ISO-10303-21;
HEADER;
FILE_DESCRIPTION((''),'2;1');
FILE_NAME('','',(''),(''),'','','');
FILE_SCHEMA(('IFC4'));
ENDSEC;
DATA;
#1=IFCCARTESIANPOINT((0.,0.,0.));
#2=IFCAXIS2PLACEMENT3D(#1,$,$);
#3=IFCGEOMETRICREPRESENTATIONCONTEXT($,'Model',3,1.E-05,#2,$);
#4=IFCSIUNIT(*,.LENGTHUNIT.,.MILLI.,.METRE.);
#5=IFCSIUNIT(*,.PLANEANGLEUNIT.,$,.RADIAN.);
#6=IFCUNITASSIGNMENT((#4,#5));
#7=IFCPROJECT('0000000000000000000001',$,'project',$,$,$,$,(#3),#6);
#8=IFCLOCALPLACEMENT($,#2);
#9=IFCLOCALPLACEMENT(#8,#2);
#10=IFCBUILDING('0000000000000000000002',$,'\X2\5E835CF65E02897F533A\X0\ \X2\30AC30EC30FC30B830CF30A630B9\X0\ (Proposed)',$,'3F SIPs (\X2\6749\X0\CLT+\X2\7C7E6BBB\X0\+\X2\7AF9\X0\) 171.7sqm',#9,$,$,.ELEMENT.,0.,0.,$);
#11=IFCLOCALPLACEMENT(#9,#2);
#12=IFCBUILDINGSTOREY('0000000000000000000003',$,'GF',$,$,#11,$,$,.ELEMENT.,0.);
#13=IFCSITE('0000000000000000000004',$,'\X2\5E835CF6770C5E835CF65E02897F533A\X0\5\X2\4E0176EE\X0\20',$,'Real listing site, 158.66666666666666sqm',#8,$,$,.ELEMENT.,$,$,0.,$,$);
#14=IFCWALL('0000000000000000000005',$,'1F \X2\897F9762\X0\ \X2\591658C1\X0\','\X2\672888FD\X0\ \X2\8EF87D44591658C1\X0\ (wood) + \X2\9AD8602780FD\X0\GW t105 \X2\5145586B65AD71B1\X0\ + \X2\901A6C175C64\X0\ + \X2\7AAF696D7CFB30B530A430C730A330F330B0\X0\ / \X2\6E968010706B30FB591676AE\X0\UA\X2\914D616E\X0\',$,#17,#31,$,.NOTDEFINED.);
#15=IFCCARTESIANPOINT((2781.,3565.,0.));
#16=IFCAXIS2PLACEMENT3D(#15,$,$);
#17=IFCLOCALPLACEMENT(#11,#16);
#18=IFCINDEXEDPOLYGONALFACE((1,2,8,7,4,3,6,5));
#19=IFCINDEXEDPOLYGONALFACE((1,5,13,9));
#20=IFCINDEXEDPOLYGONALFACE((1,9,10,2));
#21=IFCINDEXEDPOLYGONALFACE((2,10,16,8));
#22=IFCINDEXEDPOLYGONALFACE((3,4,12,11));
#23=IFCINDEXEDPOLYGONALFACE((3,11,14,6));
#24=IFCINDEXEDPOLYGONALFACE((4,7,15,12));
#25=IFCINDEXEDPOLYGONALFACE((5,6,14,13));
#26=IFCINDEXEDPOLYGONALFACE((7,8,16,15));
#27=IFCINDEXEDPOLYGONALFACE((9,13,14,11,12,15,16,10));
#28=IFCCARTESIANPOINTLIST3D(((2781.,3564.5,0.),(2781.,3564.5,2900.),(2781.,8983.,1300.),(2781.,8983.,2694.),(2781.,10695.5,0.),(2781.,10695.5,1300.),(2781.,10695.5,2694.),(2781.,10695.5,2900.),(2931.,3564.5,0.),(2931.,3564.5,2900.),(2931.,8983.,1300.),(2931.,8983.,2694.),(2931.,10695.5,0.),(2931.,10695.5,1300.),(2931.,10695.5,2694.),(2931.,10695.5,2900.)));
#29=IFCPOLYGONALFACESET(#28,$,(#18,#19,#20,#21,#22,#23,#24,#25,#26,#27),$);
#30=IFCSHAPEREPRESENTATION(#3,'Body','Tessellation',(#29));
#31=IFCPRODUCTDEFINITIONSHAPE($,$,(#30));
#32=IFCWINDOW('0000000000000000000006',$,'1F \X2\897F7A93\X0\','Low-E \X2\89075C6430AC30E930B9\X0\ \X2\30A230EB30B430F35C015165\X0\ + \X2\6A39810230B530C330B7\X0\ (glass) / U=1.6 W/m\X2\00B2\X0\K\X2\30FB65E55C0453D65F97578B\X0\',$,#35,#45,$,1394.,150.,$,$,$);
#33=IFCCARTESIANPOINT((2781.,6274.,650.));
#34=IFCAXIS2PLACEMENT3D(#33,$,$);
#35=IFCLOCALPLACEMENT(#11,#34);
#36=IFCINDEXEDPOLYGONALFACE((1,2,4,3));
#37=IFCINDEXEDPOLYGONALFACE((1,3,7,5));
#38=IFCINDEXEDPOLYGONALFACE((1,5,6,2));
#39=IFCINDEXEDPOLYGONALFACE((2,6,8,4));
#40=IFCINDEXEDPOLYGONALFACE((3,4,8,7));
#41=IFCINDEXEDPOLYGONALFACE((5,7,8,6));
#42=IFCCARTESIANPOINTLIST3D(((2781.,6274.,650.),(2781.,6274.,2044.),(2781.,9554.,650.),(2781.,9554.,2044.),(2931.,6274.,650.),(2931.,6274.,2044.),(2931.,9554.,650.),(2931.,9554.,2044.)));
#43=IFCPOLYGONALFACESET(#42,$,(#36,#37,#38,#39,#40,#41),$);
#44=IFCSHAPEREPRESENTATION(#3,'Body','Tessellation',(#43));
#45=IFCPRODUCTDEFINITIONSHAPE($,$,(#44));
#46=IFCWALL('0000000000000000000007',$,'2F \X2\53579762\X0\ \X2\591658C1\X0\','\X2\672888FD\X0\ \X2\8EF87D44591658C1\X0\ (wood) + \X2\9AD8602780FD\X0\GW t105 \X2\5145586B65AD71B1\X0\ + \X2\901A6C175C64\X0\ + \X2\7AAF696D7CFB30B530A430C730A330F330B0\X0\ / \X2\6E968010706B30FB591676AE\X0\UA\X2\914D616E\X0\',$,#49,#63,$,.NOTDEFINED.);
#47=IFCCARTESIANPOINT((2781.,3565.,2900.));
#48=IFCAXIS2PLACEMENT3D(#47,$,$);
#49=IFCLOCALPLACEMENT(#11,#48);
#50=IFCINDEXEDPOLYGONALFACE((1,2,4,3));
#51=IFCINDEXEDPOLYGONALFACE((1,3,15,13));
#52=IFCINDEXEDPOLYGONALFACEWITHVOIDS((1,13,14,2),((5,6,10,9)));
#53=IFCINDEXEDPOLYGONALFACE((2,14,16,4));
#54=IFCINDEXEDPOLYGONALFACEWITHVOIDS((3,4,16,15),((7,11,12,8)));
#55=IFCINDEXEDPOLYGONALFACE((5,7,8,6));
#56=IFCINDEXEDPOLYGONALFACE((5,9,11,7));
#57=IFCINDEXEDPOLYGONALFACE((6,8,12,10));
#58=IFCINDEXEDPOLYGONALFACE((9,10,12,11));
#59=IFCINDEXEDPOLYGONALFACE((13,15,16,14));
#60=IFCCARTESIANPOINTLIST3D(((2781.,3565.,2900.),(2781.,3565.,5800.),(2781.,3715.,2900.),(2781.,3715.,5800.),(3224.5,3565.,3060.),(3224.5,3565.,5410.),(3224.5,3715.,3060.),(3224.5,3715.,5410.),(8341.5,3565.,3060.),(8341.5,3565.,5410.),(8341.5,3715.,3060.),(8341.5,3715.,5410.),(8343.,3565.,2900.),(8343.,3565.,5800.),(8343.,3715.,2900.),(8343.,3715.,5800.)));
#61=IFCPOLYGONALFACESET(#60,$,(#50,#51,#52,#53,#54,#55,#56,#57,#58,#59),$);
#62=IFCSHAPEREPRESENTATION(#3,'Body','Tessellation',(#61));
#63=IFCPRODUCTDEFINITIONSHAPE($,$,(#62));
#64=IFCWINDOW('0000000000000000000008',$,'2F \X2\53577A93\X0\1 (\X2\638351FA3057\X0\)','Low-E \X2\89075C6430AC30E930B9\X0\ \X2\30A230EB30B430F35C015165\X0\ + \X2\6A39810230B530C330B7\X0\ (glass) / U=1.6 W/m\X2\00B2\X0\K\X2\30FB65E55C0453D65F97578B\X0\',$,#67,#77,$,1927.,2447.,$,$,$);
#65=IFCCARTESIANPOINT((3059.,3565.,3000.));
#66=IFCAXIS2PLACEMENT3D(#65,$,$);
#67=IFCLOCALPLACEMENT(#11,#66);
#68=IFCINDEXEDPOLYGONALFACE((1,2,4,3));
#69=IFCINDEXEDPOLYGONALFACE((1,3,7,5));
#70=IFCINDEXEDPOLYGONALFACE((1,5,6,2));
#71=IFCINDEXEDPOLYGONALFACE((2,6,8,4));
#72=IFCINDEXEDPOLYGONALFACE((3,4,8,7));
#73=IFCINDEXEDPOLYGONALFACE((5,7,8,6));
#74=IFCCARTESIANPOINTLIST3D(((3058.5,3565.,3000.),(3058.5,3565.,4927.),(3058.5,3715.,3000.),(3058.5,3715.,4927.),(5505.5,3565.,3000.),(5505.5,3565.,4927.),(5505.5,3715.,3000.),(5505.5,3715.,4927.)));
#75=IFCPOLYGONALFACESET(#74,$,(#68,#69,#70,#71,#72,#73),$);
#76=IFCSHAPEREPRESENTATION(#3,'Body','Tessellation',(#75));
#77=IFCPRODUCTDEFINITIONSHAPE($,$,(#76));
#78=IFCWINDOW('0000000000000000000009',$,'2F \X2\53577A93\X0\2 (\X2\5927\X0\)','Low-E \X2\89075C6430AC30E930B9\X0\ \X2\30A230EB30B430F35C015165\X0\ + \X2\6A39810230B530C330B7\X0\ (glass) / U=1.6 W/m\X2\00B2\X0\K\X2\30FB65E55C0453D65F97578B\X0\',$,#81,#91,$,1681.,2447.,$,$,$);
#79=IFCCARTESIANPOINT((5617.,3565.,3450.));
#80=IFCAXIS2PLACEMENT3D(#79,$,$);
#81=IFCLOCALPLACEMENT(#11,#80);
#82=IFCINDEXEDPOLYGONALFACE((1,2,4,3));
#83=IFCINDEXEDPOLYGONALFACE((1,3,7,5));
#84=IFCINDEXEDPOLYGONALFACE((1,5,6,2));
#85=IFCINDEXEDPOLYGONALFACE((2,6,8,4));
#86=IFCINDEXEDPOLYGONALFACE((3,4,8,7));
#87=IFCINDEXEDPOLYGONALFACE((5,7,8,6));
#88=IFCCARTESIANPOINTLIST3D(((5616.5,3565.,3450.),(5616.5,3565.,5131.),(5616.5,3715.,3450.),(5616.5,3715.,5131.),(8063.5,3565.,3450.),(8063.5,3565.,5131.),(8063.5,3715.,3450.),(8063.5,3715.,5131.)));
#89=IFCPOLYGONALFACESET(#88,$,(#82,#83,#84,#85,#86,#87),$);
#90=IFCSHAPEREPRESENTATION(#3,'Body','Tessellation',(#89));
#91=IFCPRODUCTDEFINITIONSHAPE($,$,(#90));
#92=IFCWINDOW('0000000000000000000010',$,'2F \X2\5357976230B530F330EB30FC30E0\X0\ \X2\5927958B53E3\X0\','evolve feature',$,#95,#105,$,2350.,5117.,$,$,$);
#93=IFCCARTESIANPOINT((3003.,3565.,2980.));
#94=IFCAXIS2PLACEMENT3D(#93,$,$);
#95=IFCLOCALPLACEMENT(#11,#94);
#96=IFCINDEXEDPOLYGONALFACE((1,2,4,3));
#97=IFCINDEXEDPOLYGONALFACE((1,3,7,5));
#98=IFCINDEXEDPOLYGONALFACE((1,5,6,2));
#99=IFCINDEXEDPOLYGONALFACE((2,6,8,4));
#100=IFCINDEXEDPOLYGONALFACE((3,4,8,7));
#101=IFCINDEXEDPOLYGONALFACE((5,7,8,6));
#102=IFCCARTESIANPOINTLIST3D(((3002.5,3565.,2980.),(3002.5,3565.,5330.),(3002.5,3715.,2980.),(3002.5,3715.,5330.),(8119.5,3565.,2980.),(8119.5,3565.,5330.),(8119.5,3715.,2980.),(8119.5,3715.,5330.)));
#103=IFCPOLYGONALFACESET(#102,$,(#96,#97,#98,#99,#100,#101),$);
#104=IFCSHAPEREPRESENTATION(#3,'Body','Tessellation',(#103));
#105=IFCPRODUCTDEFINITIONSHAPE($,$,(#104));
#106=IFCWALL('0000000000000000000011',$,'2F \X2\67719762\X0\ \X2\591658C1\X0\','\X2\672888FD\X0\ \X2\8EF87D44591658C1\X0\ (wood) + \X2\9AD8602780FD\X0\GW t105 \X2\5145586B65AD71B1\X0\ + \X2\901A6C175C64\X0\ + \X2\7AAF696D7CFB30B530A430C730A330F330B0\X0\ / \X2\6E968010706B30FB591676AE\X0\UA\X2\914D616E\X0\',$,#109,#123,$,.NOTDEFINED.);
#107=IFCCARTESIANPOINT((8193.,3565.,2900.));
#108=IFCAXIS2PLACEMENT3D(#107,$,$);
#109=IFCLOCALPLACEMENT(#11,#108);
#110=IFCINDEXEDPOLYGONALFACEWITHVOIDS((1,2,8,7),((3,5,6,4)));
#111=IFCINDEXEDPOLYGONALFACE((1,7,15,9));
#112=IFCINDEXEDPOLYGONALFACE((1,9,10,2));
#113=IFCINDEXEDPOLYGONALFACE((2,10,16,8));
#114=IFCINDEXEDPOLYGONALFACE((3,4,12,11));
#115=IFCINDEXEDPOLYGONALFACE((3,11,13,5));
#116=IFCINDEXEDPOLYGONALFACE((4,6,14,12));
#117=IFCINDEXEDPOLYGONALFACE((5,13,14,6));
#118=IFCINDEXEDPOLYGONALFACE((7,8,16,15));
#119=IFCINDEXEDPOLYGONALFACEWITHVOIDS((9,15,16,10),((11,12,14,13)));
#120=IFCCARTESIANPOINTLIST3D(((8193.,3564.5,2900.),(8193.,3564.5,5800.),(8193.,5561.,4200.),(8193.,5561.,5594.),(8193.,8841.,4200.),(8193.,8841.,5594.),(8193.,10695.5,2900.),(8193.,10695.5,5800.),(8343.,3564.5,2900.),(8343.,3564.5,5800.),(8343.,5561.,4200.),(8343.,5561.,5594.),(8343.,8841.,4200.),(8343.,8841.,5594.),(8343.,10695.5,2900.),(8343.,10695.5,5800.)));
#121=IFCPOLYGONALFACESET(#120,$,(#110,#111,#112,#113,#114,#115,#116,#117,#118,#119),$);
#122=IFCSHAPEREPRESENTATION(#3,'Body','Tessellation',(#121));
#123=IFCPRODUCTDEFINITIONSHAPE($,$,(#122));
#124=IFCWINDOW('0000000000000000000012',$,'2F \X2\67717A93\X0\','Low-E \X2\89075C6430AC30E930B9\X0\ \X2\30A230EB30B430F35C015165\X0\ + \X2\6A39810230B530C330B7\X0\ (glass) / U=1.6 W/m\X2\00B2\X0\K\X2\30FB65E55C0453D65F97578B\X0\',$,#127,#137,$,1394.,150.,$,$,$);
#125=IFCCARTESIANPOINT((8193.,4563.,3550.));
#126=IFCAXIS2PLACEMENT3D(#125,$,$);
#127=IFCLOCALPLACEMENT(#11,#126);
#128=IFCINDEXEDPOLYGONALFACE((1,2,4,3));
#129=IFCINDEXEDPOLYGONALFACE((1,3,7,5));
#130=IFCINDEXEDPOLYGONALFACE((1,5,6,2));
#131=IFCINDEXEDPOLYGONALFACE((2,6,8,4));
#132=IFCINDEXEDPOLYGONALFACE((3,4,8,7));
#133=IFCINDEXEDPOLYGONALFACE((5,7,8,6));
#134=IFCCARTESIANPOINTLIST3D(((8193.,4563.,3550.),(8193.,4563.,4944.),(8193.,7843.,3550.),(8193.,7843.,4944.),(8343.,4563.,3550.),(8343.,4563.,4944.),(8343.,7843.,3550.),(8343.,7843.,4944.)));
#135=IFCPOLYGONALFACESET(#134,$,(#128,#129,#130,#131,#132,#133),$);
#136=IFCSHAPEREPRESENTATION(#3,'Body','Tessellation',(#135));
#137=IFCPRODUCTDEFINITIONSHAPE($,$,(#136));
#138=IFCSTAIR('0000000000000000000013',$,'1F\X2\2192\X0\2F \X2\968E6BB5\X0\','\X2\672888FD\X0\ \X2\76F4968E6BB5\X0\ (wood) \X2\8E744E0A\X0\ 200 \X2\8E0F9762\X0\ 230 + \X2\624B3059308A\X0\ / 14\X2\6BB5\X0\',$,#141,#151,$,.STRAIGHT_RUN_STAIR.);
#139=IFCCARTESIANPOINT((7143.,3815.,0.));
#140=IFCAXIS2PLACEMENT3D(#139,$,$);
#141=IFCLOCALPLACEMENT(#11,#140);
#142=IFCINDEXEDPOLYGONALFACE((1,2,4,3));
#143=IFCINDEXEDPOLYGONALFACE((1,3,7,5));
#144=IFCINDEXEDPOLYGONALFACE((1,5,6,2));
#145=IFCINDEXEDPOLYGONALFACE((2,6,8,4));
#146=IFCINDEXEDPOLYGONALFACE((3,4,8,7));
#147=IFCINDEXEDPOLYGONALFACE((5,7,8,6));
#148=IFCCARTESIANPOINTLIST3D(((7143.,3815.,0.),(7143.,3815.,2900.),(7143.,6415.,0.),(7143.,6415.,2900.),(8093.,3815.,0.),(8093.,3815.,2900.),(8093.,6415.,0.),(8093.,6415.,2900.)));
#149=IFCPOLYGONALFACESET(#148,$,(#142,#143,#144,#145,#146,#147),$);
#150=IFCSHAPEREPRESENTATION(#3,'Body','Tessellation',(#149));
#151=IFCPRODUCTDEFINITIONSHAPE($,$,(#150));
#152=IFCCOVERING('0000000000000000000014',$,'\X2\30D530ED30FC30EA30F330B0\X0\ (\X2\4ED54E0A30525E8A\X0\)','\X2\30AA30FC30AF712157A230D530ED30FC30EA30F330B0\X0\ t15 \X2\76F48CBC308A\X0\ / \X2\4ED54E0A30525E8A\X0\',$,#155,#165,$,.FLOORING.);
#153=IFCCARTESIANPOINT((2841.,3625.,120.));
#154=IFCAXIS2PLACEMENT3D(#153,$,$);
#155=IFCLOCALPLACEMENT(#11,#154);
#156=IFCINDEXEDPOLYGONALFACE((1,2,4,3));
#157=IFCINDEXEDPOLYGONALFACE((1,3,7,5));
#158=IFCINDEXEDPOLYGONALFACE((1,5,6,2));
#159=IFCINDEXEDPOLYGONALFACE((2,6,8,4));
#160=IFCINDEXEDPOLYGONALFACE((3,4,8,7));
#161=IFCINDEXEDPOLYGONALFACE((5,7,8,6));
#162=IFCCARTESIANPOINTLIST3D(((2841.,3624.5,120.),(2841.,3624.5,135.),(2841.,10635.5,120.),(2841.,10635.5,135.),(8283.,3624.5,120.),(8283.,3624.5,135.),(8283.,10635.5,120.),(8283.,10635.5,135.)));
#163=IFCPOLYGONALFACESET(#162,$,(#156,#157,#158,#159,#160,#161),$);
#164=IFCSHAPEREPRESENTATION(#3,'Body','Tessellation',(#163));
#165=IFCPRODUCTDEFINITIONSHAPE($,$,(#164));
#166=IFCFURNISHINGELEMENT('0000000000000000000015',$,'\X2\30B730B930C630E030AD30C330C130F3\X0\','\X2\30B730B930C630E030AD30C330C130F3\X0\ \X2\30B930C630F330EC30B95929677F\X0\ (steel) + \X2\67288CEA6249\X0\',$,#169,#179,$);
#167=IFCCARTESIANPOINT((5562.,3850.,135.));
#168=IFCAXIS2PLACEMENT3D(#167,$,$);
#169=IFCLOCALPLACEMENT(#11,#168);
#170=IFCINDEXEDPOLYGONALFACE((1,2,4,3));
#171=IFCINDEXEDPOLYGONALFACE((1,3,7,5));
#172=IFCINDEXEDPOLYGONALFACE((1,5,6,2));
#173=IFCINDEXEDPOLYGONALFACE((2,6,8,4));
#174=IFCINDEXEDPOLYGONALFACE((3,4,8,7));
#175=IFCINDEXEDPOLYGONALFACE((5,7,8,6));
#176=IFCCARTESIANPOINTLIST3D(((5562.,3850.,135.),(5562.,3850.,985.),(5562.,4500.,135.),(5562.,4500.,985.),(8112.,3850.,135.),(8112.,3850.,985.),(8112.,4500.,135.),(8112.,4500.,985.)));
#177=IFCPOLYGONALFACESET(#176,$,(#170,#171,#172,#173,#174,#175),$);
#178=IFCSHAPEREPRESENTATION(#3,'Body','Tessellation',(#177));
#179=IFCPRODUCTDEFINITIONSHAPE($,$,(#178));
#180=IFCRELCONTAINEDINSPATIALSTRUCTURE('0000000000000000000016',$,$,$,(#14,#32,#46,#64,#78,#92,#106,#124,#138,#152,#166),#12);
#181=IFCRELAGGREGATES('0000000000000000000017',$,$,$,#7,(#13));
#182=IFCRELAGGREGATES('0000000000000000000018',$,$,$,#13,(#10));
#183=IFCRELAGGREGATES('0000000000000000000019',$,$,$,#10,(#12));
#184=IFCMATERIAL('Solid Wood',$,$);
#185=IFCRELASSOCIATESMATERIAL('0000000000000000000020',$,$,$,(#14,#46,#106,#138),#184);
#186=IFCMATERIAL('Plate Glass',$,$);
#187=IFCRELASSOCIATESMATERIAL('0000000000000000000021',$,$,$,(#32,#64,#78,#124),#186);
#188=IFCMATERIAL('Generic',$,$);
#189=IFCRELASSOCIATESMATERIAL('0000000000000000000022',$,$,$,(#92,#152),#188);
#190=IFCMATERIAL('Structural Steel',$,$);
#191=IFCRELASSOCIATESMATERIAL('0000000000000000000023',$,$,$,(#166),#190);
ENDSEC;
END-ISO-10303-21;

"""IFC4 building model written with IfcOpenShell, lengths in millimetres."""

from ifc_helpers import new_model, si_unit, frame, frame_2d, origin, place, context, project, spatial, rectangle, extrude, material, element, fill, save


model = new_model("IFC4")

# Units and contexts
model_context = context("Model", 3, precision=1e-05, world=origin())
ifc_project = project(units=[si_unit("LENGTHUNIT", "METRE", prefix="MILLI"), si_unit("PLANEANGLEUNIT", "RADIAN")], contexts=[model_context])

# Site, building, storey
site_placement = place(None, origin())
site = spatial("IfcSite", under=ifc_project, at=site_placement, Name="広島県広島市西区5丁目20", ObjectType="Real listing site, 158.66666666666666sqm", CompositionType="ELEMENT", RefElevation=0.0)
building_placement = place(site_placement, origin())
building = spatial("IfcBuilding", under=site, at=building_placement, Name="広島市西区 ガレージハウス (Proposed)", ObjectType="3F SIPs (杉CLT+籾殻+竹) 171.7sqm", CompositionType="ELEMENT", ElevationOfRefHeight=0.0, ElevationOfTerrain=0.0)
storey_placement = place(building_placement, origin())
storey = spatial("IfcBuildingStorey", under=building, at=storey_placement, Name="GF", CompositionType="ELEMENT", Elevation=0.0)

# Shared definitions
ifc_material_1 = material(Name="Solid Wood")

# Shared definitions
ifc_material_2 = material(Name="Plate Glass")
ifc_material_3 = material(Name="Generic")

# Wall, opening, window
wall_1_placement = place(storey_placement, frame((2781.0, 3565.0, 0.0)))
wall_1 = element("IfcWall", 1, at=wall_1_placement, inside=storey, material=ifc_material_1, Name="1F 西面 外壁", Description="木製 軸組外壁 (wood) + 高性能GW t105 充填断熱 + 通気層 + 窯業系サイディング / 準耐火・外皮UA配慮", PredefinedType="NOTDEFINED", context=model_context, shape_type="SweptSolid", body=[
    extrude(rectangle(XDim=150.0, YDim=7131.0, at=frame_2d((75.0, 3565.0))), frame((2781.0, 3565.0, 0.0)), (0.0, 0.0, 1.0), 2900.0),
])
opening_1_placement = place(storey_placement, frame((2781.0, 6274.0, 650.0)))
opening_1 = element("IfcOpeningElement", 2, at=opening_1_placement, cuts=wall_1, PredefinedType="NOTDEFINED", context=model_context, shape_type="SweptSolid", body=[
    extrude(rectangle(XDim=150.0, YDim=3280.0, at=frame_2d((75.0, 1640.0))), frame((2781.0, 6274.0, 650.0)), (0.0, 0.0, 1.0), 1394.0),
])
window_1_placement = place(storey_placement, frame((2781.0, 6274.0, 650.0)))
window_1 = element("IfcWindow", 3, at=window_1_placement, inside=storey, material=ifc_material_2, Name="1F 西窓", Description="Low-E 複層ガラス アルゴン封入 + 樹脂サッシ (glass) / U=1.6 W/m²K・日射取得型", OverallHeight=1394.0, OverallWidth=150.0, context=model_context, shape_type="SweptSolid", body=[
    extrude(rectangle(XDim=150.0, YDim=3280.0, at=frame_2d((75.0, 1640.0))), frame((2781.0, 6274.0, 650.0)), (0.0, 0.0, 1.0), 1394.0),
])
fill(opening_1, window_1)

# Wall, openings, windows
wall_2_placement = place(storey_placement, frame((2781.0, 3565.0, 2900.0)))
wall_2 = element("IfcWall", 4, at=wall_2_placement, inside=storey, material=ifc_material_1, Name="2F 南面 外壁", Description="木製 軸組外壁 (wood) + 高性能GW t105 充填断熱 + 通気層 + 窯業系サイディング / 準耐火・外皮UA配慮", PredefinedType="NOTDEFINED", context=model_context, shape_type="SweptSolid", body=[
    extrude(rectangle(XDim=5562.0, YDim=150.0, at=frame_2d((2781.0, 75.0))), frame((2781.0, 3565.0, 2900.0)), (0.0, 0.0, 1.0), 2900.0),
])
opening_2_placement = place(storey_placement, frame((3059.0, 3565.0, 3000.0)))
opening_2 = element("IfcOpeningElement", 5, at=opening_2_placement, cuts=wall_2, PredefinedType="NOTDEFINED", context=model_context, shape_type="SweptSolid", body=[
    extrude(rectangle(XDim=2447.0, YDim=150.0, at=frame_2d((1223.0, 75.0))), frame((3059.0, 3565.0, 3000.0)), (0.0, 0.0, 1.0), 1927.0),
])
opening_3_placement = place(storey_placement, frame((5617.0, 3565.0, 3450.0)))
opening_3 = element("IfcOpeningElement", 6, at=opening_3_placement, cuts=wall_2, PredefinedType="NOTDEFINED", context=model_context, shape_type="SweptSolid", body=[
    extrude(rectangle(XDim=2447.0, YDim=150.0, at=frame_2d((1223.0, 75.0))), frame((5617.0, 3565.0, 3450.0)), (0.0, 0.0, 1.0), 1681.0),
])
opening_4_placement = place(storey_placement, frame((3003.0, 3565.0, 2980.0)))
opening_4 = element("IfcOpeningElement", 7, at=opening_4_placement, cuts=wall_2, PredefinedType="NOTDEFINED", context=model_context, shape_type="SweptSolid", body=[
    extrude(rectangle(XDim=5117.0, YDim=150.0, at=frame_2d((2558.0, 75.0))), frame((3003.0, 3565.0, 2980.0)), (0.0, 0.0, 1.0), 2350.0),
])
window_2_placement = place(storey_placement, frame((3059.0, 3565.0, 3000.0)))
window_2 = element("IfcWindow", 8, at=window_2_placement, inside=storey, material=ifc_material_2, Name="2F 南窓1 (掃出し)", Description="Low-E 複層ガラス アルゴン封入 + 樹脂サッシ (glass) / U=1.6 W/m²K・日射取得型", OverallHeight=1927.0, OverallWidth=2447.0, context=model_context, shape_type="SweptSolid", body=[
    extrude(rectangle(XDim=2447.0, YDim=150.0, at=frame_2d((1223.0, 75.0))), frame((3059.0, 3565.0, 3000.0)), (0.0, 0.0, 1.0), 1927.0),
])
fill(opening_2, window_2)
window_3_placement = place(storey_placement, frame((5617.0, 3565.0, 3450.0)))
window_3 = element("IfcWindow", 9, at=window_3_placement, inside=storey, material=ifc_material_2, Name="2F 南窓2 (大)", Description="Low-E 複層ガラス アルゴン封入 + 樹脂サッシ (glass) / U=1.6 W/m²K・日射取得型", OverallHeight=1681.0, OverallWidth=2447.0, context=model_context, shape_type="SweptSolid", body=[
    extrude(rectangle(XDim=2447.0, YDim=150.0, at=frame_2d((1223.0, 75.0))), frame((5617.0, 3565.0, 3450.0)), (0.0, 0.0, 1.0), 1681.0),
])
fill(opening_3, window_3)
window_4_placement = place(storey_placement, frame((3003.0, 3565.0, 2980.0)))
window_4 = element("IfcWindow", 10, at=window_4_placement, inside=storey, material=ifc_material_3, Name="2F 南面サンルーム 大開口", Description="evolve feature", OverallHeight=2350.0, OverallWidth=5117.0, context=model_context, shape_type="SweptSolid", body=[
    extrude(rectangle(XDim=5117.0, YDim=150.0, at=frame_2d((2558.0, 75.0))), frame((3003.0, 3565.0, 2980.0)), (0.0, 0.0, 1.0), 2350.0),
])
fill(opening_4, window_4)

# Wall, opening, window
wall_3_placement = place(storey_placement, frame((8193.0, 3565.0, 2900.0)))
wall_3 = element("IfcWall", 11, at=wall_3_placement, inside=storey, material=ifc_material_1, Name="2F 東面 外壁", Description="木製 軸組外壁 (wood) + 高性能GW t105 充填断熱 + 通気層 + 窯業系サイディング / 準耐火・外皮UA配慮", PredefinedType="NOTDEFINED", context=model_context, shape_type="SweptSolid", body=[
    extrude(rectangle(XDim=150.0, YDim=7131.0, at=frame_2d((75.0, 3565.0))), frame((8193.0, 3565.0, 2900.0)), (0.0, 0.0, 1.0), 2900.0),
])
opening_5_placement = place(storey_placement, frame((8193.0, 4563.0, 3550.0)))
opening_5 = element("IfcOpeningElement", 12, at=opening_5_placement, cuts=wall_3, PredefinedType="NOTDEFINED", context=model_context, shape_type="SweptSolid", body=[
    extrude(rectangle(XDim=150.0, YDim=3280.0, at=frame_2d((75.0, 1640.0))), frame((8193.0, 4563.0, 3550.0)), (0.0, 0.0, 1.0), 1394.0),
])
window_5_placement = place(storey_placement, frame((8193.0, 4563.0, 3550.0)))
window_5 = element("IfcWindow", 13, at=window_5_placement, inside=storey, material=ifc_material_2, Name="2F 東窓", Description="Low-E 複層ガラス アルゴン封入 + 樹脂サッシ (glass) / U=1.6 W/m²K・日射取得型", OverallHeight=1394.0, OverallWidth=150.0, context=model_context, shape_type="SweptSolid", body=[
    extrude(rectangle(XDim=150.0, YDim=3280.0, at=frame_2d((75.0, 1640.0))), frame((8193.0, 4563.0, 3550.0)), (0.0, 0.0, 1.0), 1394.0),
])
fill(opening_5, window_5)

# Stair
stair_placement = place(storey_placement, frame((7143.0, 3815.0, 0.0)))
element("IfcStair", 14, at=stair_placement, inside=storey, material=ifc_material_1, Name="1F→2F 階段", Description="木製 直階段 (wood) 蹴上 200 踏面 230 + 手すり / 14段", PredefinedType="STRAIGHT_RUN_STAIR", context=model_context, shape_type="SweptSolid", body=[
    extrude(rectangle(XDim=950.0, YDim=2600.0, at=frame_2d((475.0, 1300.0))), frame((7143.0, 3815.0, 0.0)), (0.0, 0.0, 1.0), 2900.0),
])

# Covering
covering_placement = place(storey_placement, frame((2841.0, 3625.0, 120.0)))
element("IfcCovering", 15, at=covering_placement, inside=storey, material=ifc_material_3, Name="フローリング (仕上げ床)", Description="オーク無垢フローリング t15 直貼り / 仕上げ床", PredefinedType="FLOORING", context=model_context, shape_type="SweptSolid", body=[
    extrude(rectangle(XDim=5442.0, YDim=7011.0, at=frame_2d((2721.0, 3505.0))), frame((2841.0, 3625.0, 120.0)), (0.0, 0.0, 1.0), 15.0),
])

# Furnishing element
ifc_material_4 = material(Name="Structural Steel")
furnishing_placement = place(storey_placement, frame((5562.0, 3850.0, 135.0)))
element("IfcFurnishingElement", 16, at=furnishing_placement, inside=storey, material=ifc_material_4, Name="システムキッチン", Description="システムキッチン ステンレス天板 (steel) + 木質扉", context=model_context, shape_type="SweptSolid", body=[
    extrude(rectangle(XDim=2550.0, YDim=650.0, at=frame_2d((1275.0, 325.0))), frame((5562.0, 3850.0, 135.0)), (0.0, 0.0, 1.0), 850.0),
])

save(model, "model.ifc")
